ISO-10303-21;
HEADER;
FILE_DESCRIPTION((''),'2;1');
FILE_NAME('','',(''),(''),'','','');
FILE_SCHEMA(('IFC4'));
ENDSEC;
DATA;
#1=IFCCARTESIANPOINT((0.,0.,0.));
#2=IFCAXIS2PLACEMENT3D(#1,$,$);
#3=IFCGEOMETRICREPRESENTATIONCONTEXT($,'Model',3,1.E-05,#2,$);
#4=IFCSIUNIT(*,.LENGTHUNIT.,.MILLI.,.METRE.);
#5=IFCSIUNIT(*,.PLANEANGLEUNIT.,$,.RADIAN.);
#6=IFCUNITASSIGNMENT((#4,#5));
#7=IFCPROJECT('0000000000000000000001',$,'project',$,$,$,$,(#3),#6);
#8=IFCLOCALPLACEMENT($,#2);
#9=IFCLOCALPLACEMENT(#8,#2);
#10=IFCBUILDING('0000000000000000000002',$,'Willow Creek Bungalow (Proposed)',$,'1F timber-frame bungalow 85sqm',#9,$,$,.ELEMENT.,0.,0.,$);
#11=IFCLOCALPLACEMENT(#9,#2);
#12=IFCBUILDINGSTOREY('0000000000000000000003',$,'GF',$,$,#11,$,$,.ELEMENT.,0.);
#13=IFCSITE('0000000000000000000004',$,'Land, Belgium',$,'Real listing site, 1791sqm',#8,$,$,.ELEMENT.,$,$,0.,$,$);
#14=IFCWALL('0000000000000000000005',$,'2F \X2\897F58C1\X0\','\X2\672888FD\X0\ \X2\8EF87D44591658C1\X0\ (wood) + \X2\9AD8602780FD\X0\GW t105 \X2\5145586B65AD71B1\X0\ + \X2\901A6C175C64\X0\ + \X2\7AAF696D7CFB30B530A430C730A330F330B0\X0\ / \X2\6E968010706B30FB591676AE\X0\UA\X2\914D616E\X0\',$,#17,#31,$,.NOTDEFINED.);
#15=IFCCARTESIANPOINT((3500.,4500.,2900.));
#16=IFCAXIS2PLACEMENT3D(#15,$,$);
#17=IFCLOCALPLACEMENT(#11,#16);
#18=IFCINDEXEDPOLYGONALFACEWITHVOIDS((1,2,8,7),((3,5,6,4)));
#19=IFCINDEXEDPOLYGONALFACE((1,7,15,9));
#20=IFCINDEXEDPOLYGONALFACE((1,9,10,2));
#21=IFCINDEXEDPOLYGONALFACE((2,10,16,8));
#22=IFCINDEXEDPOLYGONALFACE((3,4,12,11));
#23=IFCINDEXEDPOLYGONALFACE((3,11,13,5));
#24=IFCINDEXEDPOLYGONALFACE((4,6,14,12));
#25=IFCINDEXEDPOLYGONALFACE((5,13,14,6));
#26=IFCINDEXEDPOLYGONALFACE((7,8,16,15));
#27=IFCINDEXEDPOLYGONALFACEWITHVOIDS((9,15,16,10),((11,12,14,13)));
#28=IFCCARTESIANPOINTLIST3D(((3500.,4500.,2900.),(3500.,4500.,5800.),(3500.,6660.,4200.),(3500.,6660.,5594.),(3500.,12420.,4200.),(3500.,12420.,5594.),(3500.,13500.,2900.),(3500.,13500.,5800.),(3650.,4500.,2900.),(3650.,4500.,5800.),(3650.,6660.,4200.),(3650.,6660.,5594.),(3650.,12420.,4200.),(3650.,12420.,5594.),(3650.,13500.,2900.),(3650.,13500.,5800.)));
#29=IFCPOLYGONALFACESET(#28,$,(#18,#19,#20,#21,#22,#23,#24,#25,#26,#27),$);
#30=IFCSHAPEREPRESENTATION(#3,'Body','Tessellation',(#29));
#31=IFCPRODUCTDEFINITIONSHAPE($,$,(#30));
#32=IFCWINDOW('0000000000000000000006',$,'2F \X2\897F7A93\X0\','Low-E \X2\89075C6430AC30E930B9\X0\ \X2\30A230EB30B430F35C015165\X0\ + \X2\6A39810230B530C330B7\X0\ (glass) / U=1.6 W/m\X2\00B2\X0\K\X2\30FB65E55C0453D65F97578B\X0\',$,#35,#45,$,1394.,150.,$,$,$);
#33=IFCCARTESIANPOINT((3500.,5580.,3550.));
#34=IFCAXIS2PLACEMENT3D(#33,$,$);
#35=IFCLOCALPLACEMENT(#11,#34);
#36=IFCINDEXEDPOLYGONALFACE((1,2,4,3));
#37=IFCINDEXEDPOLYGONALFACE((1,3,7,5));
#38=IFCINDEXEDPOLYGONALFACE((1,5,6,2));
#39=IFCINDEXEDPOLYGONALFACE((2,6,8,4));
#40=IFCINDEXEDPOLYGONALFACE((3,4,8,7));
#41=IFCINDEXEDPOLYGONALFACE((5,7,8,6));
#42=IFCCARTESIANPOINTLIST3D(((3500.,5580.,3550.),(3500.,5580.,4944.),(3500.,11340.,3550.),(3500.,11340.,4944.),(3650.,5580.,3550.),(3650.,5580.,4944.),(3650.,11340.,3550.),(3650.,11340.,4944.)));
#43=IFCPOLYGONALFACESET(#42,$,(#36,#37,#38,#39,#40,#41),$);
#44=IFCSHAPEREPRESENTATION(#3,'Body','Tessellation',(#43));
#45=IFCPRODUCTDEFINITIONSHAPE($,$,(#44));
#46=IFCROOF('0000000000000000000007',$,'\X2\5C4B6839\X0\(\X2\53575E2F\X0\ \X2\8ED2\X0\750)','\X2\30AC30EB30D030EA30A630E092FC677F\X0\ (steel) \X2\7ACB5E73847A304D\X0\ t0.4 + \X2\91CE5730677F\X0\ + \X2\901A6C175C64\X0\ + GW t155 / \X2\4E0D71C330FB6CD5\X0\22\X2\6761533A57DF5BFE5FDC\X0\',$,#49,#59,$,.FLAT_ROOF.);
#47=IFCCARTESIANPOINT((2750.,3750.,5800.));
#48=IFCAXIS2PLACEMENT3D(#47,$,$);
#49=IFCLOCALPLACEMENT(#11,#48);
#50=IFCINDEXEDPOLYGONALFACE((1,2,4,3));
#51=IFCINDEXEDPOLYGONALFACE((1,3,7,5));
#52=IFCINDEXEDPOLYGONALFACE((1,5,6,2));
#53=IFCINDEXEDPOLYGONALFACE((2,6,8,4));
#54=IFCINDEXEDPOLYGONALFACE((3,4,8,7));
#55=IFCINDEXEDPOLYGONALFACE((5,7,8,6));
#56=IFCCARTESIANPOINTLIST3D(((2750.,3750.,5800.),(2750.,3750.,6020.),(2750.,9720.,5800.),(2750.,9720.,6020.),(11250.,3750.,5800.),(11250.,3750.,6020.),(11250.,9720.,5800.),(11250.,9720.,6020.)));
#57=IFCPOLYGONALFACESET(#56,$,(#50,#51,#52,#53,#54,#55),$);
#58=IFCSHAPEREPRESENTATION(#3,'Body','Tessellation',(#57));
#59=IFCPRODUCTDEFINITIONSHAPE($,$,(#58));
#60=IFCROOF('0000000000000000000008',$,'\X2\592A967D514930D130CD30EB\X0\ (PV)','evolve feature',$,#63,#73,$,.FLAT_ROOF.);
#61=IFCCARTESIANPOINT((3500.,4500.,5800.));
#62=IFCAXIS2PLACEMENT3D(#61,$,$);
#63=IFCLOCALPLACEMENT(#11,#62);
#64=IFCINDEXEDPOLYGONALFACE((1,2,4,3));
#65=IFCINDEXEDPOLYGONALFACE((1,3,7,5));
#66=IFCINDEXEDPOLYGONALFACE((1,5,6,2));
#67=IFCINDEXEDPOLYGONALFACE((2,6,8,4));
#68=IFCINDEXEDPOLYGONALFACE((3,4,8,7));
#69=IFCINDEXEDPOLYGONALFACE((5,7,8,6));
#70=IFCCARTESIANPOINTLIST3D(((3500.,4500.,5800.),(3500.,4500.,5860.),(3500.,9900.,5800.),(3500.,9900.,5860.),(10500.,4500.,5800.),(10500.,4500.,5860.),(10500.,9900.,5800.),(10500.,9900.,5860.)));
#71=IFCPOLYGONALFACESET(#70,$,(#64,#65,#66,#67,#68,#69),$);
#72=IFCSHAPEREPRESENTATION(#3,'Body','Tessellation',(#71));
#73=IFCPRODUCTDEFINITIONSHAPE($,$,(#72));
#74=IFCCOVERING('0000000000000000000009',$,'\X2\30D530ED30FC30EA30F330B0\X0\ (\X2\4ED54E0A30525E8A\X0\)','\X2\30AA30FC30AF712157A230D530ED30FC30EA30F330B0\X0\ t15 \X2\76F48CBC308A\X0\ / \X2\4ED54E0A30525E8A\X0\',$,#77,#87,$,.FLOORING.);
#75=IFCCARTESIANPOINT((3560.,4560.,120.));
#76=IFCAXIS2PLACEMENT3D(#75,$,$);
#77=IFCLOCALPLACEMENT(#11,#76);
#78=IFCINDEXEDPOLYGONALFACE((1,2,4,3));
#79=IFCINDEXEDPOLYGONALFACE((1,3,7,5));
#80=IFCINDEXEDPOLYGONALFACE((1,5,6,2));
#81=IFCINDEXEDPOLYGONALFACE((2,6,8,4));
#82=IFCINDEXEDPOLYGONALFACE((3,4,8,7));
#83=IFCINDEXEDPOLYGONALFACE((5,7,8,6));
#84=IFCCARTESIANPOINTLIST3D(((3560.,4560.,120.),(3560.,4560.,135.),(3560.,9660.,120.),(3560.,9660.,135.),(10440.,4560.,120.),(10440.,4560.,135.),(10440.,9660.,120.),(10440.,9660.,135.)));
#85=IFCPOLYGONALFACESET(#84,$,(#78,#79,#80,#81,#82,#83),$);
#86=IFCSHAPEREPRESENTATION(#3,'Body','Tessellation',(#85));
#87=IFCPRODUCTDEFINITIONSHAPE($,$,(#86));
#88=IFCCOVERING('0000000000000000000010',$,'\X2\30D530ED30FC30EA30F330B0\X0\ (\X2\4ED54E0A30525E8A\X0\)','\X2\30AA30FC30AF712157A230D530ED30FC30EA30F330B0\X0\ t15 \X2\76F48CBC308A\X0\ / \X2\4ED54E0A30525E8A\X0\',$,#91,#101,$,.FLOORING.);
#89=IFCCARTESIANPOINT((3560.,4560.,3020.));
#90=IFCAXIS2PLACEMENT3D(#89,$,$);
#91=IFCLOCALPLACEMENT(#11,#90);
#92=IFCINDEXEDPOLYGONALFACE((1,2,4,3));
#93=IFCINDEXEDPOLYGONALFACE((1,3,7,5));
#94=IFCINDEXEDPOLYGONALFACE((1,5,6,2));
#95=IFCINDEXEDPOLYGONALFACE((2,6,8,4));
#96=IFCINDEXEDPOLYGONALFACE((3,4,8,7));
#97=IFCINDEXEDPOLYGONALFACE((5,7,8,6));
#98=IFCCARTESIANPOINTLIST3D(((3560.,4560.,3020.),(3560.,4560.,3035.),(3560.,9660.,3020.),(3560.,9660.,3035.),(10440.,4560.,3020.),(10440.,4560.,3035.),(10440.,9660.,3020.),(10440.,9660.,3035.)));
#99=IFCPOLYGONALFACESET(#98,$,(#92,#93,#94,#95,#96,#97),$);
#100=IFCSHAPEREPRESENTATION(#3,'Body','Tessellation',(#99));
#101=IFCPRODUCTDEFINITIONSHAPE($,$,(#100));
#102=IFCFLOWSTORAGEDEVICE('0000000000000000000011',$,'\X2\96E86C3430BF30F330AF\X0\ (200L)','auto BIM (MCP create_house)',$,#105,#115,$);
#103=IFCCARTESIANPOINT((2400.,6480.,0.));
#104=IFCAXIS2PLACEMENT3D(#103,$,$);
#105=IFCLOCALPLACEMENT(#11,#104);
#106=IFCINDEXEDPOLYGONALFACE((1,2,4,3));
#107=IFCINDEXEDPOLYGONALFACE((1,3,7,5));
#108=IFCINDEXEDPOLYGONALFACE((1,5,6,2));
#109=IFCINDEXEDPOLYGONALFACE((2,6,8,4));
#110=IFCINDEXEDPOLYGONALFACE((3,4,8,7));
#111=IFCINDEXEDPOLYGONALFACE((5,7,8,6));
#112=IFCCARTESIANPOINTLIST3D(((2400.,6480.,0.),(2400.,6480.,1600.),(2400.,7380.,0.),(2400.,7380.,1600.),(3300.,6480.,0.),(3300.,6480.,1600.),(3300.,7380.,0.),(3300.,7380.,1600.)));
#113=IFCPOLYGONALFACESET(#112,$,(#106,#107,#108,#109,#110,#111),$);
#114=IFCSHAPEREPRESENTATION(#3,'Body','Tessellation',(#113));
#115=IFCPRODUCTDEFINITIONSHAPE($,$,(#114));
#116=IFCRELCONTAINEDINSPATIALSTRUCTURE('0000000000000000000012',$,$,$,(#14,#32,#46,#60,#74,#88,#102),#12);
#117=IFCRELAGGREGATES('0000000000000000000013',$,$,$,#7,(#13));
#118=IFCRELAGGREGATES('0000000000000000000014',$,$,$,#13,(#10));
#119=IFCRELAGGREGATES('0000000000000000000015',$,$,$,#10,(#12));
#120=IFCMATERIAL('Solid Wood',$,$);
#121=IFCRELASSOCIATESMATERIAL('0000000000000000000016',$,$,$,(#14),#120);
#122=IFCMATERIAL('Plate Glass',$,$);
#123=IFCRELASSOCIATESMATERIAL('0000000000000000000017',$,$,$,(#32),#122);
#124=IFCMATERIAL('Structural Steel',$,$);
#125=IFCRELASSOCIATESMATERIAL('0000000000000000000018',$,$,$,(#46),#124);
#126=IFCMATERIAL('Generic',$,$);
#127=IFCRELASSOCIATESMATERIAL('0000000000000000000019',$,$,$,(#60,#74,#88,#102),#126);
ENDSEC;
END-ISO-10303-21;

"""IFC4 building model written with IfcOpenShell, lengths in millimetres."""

from ifc_helpers import new_model, si_unit, frame, frame_2d, origin, place, context, project, spatial, rectangle, extrude, material, element, fill, save


model = new_model("IFC4")

# Units and contexts
model_context = context("Model", 3, precision=1e-05, world=origin())
ifc_project = project(units=[si_unit("LENGTHUNIT", "METRE", prefix="MILLI"), si_unit("PLANEANGLEUNIT", "RADIAN")], contexts=[model_context])

# Site, building, storey
site_placement = place(None, origin())
site = spatial("IfcSite", under=ifc_project, at=site_placement, Name="Land, Belgium", ObjectType="Real listing site, 1791sqm", CompositionType="ELEMENT", RefElevation=0.0)
building_placement = place(site_placement, origin())
building = spatial("IfcBuilding", under=site, at=building_placement, Name="Willow Creek Bungalow (Proposed)", ObjectType="1F timber-frame bungalow 85sqm", CompositionType="ELEMENT", ElevationOfRefHeight=0.0, ElevationOfTerrain=0.0)
storey_placement = place(building_placement, origin())
storey = spatial("IfcBuildingStorey", under=building, at=storey_placement, Name="GF", CompositionType="ELEMENT", Elevation=0.0)

# Shared definitions
ifc_material_1 = material(Name="Solid Wood")
ifc_material_2 = material(Name="Generic")

# Shared definitions
ifc_material_3 = material(Name="Plate Glass")

# Wall, opening, window
wall_1_placement = place(storey_placement, frame((3500.0, 4500.0, 2900.0)))
wall_1 = element("IfcWall", 1, at=wall_1_placement, inside=storey, material=ifc_material_1, Name="2F 西壁", Description="木製 軸組外壁 (wood) + 高性能GW t105 充填断熱 + 通気層 + 窯業系サイディング / 準耐火・外皮UA配慮", PredefinedType="NOTDEFINED", context=model_context, shape_type="SweptSolid", body=[
    extrude(rectangle(XDim=150.0, YDim=9000.0, at=frame_2d((75.0, 4500.0))), frame((3500.0, 4500.0, 2900.0)), (0.0, 0.0, 1.0), 2900.0),
])
opening_1_placement = place(storey_placement, frame((3500.0, 5580.0, 3550.0)))
opening_1 = element("IfcOpeningElement", 2, at=opening_1_placement, cuts=wall_1, PredefinedType="NOTDEFINED", context=model_context, shape_type="SweptSolid", body=[
    extrude(rectangle(XDim=150.0, YDim=5760.0, at=frame_2d((75.0, 2880.0))), frame((3500.0, 5580.0, 3550.0)), (0.0, 0.0, 1.0), 1394.0),
])
window_1_placement = place(storey_placement, frame((3500.0, 5580.0, 3550.0)))
window_1 = element("IfcWindow", 3, at=window_1_placement, inside=storey, material=ifc_material_3, Name="2F 西窓", Description="Low-E 複層ガラス アルゴン封入 + 樹脂サッシ (glass) / U=1.6 W/m²K・日射取得型", OverallHeight=1394.0, OverallWidth=150.0, context=model_context, shape_type="SweptSolid", body=[
    extrude(rectangle(XDim=150.0, YDim=5760.0, at=frame_2d((75.0, 2880.0))), frame((3500.0, 5580.0, 3550.0)), (0.0, 0.0, 1.0), 1394.0),
])
fill(opening_1, window_1)

# Roofs
ifc_material_4 = material(Name="Structural Steel")
for number, where, name in (
    (4, (2750.0, 3750.0, 5800.0), "屋根(南帯 軒750)"),
):
    element("IfcRoof", number, at=place(storey_placement, frame(where)), inside=storey, material=ifc_material_4, Name=name, Description="ガルバリウム鋼板 (steel) 立平葺き t0.4 + 野地板 + 通気層 + GW t155 / 不燃・法22条区域対応", PredefinedType="FLAT_ROOF", context=model_context, shape_type="SweptSolid", body=[
        extrude(rectangle(XDim=8500.0, YDim=5970.0, at=frame_2d((4250.0, 2985.0))), frame((2750.0, 3750.0, 5800.0)), (0.0, 0.0, 1.0), 220.0),
    ])
roof_placement = place(storey_placement, frame((3500.0, 4500.0, 5800.0)))
element("IfcRoof", 5, at=roof_placement, inside=storey, material=ifc_material_2, Name="太陽光パネル (PV)", Description="evolve feature", PredefinedType="FLAT_ROOF", context=model_context, shape_type="SweptSolid", body=[
    extrude(rectangle(XDim=7000.0, YDim=5400.0, at=frame_2d((3500.0, 2700.0))), frame((3500.0, 4500.0, 5800.0)), (0.0, 0.0, 1.0), 60.0),
])

# Coverings
covering_1_placement = place(storey_placement, frame((3560.0, 4560.0, 120.0)))
element("IfcCovering", 6, at=covering_1_placement, inside=storey, material=ifc_material_2, Name="フローリング (仕上げ床)", Description="オーク無垢フローリング t15 直貼り / 仕上げ床", PredefinedType="FLOORING", context=model_context, shape_type="SweptSolid", body=[
    extrude(rectangle(XDim=6880.0, YDim=5100.0, at=frame_2d((3440.0, 2550.0))), frame((3560.0, 4560.0, 120.0)), (0.0, 0.0, 1.0), 15.0),
])
covering_2_placement = place(storey_placement, frame((3560.0, 4560.0, 3020.0)))
element("IfcCovering", 7, at=covering_2_placement, inside=storey, material=ifc_material_2, Name="フローリング (仕上げ床)", Description="オーク無垢フローリング t15 直貼り / 仕上げ床", PredefinedType="FLOORING", context=model_context, shape_type="SweptSolid", body=[
    extrude(rectangle(XDim=6880.0, YDim=5100.0, at=frame_2d((3440.0, 2550.0))), frame((3560.0, 4560.0, 3020.0)), (0.0, 0.0, 1.0), 15.0),
])

# Flow storage device
flow_storage_device_placement = place(storey_placement, frame((2400.0, 6480.0, 0.0)))
element("IfcFlowStorageDevice", 8, at=flow_storage_device_placement, inside=storey, material=ifc_material_2, Name="雨水タンク (200L)", Description="auto BIM (MCP create_house)", context=model_context, shape_type="SweptSolid", body=[
    extrude(rectangle(XDim=900.0, YDim=900.0, at=frame_2d((450.0, 450.0))), frame((2400.0, 6480.0, 0.0)), (0.0, 0.0, 1.0), 1600.0),
])

save(model, "model.ifc")
